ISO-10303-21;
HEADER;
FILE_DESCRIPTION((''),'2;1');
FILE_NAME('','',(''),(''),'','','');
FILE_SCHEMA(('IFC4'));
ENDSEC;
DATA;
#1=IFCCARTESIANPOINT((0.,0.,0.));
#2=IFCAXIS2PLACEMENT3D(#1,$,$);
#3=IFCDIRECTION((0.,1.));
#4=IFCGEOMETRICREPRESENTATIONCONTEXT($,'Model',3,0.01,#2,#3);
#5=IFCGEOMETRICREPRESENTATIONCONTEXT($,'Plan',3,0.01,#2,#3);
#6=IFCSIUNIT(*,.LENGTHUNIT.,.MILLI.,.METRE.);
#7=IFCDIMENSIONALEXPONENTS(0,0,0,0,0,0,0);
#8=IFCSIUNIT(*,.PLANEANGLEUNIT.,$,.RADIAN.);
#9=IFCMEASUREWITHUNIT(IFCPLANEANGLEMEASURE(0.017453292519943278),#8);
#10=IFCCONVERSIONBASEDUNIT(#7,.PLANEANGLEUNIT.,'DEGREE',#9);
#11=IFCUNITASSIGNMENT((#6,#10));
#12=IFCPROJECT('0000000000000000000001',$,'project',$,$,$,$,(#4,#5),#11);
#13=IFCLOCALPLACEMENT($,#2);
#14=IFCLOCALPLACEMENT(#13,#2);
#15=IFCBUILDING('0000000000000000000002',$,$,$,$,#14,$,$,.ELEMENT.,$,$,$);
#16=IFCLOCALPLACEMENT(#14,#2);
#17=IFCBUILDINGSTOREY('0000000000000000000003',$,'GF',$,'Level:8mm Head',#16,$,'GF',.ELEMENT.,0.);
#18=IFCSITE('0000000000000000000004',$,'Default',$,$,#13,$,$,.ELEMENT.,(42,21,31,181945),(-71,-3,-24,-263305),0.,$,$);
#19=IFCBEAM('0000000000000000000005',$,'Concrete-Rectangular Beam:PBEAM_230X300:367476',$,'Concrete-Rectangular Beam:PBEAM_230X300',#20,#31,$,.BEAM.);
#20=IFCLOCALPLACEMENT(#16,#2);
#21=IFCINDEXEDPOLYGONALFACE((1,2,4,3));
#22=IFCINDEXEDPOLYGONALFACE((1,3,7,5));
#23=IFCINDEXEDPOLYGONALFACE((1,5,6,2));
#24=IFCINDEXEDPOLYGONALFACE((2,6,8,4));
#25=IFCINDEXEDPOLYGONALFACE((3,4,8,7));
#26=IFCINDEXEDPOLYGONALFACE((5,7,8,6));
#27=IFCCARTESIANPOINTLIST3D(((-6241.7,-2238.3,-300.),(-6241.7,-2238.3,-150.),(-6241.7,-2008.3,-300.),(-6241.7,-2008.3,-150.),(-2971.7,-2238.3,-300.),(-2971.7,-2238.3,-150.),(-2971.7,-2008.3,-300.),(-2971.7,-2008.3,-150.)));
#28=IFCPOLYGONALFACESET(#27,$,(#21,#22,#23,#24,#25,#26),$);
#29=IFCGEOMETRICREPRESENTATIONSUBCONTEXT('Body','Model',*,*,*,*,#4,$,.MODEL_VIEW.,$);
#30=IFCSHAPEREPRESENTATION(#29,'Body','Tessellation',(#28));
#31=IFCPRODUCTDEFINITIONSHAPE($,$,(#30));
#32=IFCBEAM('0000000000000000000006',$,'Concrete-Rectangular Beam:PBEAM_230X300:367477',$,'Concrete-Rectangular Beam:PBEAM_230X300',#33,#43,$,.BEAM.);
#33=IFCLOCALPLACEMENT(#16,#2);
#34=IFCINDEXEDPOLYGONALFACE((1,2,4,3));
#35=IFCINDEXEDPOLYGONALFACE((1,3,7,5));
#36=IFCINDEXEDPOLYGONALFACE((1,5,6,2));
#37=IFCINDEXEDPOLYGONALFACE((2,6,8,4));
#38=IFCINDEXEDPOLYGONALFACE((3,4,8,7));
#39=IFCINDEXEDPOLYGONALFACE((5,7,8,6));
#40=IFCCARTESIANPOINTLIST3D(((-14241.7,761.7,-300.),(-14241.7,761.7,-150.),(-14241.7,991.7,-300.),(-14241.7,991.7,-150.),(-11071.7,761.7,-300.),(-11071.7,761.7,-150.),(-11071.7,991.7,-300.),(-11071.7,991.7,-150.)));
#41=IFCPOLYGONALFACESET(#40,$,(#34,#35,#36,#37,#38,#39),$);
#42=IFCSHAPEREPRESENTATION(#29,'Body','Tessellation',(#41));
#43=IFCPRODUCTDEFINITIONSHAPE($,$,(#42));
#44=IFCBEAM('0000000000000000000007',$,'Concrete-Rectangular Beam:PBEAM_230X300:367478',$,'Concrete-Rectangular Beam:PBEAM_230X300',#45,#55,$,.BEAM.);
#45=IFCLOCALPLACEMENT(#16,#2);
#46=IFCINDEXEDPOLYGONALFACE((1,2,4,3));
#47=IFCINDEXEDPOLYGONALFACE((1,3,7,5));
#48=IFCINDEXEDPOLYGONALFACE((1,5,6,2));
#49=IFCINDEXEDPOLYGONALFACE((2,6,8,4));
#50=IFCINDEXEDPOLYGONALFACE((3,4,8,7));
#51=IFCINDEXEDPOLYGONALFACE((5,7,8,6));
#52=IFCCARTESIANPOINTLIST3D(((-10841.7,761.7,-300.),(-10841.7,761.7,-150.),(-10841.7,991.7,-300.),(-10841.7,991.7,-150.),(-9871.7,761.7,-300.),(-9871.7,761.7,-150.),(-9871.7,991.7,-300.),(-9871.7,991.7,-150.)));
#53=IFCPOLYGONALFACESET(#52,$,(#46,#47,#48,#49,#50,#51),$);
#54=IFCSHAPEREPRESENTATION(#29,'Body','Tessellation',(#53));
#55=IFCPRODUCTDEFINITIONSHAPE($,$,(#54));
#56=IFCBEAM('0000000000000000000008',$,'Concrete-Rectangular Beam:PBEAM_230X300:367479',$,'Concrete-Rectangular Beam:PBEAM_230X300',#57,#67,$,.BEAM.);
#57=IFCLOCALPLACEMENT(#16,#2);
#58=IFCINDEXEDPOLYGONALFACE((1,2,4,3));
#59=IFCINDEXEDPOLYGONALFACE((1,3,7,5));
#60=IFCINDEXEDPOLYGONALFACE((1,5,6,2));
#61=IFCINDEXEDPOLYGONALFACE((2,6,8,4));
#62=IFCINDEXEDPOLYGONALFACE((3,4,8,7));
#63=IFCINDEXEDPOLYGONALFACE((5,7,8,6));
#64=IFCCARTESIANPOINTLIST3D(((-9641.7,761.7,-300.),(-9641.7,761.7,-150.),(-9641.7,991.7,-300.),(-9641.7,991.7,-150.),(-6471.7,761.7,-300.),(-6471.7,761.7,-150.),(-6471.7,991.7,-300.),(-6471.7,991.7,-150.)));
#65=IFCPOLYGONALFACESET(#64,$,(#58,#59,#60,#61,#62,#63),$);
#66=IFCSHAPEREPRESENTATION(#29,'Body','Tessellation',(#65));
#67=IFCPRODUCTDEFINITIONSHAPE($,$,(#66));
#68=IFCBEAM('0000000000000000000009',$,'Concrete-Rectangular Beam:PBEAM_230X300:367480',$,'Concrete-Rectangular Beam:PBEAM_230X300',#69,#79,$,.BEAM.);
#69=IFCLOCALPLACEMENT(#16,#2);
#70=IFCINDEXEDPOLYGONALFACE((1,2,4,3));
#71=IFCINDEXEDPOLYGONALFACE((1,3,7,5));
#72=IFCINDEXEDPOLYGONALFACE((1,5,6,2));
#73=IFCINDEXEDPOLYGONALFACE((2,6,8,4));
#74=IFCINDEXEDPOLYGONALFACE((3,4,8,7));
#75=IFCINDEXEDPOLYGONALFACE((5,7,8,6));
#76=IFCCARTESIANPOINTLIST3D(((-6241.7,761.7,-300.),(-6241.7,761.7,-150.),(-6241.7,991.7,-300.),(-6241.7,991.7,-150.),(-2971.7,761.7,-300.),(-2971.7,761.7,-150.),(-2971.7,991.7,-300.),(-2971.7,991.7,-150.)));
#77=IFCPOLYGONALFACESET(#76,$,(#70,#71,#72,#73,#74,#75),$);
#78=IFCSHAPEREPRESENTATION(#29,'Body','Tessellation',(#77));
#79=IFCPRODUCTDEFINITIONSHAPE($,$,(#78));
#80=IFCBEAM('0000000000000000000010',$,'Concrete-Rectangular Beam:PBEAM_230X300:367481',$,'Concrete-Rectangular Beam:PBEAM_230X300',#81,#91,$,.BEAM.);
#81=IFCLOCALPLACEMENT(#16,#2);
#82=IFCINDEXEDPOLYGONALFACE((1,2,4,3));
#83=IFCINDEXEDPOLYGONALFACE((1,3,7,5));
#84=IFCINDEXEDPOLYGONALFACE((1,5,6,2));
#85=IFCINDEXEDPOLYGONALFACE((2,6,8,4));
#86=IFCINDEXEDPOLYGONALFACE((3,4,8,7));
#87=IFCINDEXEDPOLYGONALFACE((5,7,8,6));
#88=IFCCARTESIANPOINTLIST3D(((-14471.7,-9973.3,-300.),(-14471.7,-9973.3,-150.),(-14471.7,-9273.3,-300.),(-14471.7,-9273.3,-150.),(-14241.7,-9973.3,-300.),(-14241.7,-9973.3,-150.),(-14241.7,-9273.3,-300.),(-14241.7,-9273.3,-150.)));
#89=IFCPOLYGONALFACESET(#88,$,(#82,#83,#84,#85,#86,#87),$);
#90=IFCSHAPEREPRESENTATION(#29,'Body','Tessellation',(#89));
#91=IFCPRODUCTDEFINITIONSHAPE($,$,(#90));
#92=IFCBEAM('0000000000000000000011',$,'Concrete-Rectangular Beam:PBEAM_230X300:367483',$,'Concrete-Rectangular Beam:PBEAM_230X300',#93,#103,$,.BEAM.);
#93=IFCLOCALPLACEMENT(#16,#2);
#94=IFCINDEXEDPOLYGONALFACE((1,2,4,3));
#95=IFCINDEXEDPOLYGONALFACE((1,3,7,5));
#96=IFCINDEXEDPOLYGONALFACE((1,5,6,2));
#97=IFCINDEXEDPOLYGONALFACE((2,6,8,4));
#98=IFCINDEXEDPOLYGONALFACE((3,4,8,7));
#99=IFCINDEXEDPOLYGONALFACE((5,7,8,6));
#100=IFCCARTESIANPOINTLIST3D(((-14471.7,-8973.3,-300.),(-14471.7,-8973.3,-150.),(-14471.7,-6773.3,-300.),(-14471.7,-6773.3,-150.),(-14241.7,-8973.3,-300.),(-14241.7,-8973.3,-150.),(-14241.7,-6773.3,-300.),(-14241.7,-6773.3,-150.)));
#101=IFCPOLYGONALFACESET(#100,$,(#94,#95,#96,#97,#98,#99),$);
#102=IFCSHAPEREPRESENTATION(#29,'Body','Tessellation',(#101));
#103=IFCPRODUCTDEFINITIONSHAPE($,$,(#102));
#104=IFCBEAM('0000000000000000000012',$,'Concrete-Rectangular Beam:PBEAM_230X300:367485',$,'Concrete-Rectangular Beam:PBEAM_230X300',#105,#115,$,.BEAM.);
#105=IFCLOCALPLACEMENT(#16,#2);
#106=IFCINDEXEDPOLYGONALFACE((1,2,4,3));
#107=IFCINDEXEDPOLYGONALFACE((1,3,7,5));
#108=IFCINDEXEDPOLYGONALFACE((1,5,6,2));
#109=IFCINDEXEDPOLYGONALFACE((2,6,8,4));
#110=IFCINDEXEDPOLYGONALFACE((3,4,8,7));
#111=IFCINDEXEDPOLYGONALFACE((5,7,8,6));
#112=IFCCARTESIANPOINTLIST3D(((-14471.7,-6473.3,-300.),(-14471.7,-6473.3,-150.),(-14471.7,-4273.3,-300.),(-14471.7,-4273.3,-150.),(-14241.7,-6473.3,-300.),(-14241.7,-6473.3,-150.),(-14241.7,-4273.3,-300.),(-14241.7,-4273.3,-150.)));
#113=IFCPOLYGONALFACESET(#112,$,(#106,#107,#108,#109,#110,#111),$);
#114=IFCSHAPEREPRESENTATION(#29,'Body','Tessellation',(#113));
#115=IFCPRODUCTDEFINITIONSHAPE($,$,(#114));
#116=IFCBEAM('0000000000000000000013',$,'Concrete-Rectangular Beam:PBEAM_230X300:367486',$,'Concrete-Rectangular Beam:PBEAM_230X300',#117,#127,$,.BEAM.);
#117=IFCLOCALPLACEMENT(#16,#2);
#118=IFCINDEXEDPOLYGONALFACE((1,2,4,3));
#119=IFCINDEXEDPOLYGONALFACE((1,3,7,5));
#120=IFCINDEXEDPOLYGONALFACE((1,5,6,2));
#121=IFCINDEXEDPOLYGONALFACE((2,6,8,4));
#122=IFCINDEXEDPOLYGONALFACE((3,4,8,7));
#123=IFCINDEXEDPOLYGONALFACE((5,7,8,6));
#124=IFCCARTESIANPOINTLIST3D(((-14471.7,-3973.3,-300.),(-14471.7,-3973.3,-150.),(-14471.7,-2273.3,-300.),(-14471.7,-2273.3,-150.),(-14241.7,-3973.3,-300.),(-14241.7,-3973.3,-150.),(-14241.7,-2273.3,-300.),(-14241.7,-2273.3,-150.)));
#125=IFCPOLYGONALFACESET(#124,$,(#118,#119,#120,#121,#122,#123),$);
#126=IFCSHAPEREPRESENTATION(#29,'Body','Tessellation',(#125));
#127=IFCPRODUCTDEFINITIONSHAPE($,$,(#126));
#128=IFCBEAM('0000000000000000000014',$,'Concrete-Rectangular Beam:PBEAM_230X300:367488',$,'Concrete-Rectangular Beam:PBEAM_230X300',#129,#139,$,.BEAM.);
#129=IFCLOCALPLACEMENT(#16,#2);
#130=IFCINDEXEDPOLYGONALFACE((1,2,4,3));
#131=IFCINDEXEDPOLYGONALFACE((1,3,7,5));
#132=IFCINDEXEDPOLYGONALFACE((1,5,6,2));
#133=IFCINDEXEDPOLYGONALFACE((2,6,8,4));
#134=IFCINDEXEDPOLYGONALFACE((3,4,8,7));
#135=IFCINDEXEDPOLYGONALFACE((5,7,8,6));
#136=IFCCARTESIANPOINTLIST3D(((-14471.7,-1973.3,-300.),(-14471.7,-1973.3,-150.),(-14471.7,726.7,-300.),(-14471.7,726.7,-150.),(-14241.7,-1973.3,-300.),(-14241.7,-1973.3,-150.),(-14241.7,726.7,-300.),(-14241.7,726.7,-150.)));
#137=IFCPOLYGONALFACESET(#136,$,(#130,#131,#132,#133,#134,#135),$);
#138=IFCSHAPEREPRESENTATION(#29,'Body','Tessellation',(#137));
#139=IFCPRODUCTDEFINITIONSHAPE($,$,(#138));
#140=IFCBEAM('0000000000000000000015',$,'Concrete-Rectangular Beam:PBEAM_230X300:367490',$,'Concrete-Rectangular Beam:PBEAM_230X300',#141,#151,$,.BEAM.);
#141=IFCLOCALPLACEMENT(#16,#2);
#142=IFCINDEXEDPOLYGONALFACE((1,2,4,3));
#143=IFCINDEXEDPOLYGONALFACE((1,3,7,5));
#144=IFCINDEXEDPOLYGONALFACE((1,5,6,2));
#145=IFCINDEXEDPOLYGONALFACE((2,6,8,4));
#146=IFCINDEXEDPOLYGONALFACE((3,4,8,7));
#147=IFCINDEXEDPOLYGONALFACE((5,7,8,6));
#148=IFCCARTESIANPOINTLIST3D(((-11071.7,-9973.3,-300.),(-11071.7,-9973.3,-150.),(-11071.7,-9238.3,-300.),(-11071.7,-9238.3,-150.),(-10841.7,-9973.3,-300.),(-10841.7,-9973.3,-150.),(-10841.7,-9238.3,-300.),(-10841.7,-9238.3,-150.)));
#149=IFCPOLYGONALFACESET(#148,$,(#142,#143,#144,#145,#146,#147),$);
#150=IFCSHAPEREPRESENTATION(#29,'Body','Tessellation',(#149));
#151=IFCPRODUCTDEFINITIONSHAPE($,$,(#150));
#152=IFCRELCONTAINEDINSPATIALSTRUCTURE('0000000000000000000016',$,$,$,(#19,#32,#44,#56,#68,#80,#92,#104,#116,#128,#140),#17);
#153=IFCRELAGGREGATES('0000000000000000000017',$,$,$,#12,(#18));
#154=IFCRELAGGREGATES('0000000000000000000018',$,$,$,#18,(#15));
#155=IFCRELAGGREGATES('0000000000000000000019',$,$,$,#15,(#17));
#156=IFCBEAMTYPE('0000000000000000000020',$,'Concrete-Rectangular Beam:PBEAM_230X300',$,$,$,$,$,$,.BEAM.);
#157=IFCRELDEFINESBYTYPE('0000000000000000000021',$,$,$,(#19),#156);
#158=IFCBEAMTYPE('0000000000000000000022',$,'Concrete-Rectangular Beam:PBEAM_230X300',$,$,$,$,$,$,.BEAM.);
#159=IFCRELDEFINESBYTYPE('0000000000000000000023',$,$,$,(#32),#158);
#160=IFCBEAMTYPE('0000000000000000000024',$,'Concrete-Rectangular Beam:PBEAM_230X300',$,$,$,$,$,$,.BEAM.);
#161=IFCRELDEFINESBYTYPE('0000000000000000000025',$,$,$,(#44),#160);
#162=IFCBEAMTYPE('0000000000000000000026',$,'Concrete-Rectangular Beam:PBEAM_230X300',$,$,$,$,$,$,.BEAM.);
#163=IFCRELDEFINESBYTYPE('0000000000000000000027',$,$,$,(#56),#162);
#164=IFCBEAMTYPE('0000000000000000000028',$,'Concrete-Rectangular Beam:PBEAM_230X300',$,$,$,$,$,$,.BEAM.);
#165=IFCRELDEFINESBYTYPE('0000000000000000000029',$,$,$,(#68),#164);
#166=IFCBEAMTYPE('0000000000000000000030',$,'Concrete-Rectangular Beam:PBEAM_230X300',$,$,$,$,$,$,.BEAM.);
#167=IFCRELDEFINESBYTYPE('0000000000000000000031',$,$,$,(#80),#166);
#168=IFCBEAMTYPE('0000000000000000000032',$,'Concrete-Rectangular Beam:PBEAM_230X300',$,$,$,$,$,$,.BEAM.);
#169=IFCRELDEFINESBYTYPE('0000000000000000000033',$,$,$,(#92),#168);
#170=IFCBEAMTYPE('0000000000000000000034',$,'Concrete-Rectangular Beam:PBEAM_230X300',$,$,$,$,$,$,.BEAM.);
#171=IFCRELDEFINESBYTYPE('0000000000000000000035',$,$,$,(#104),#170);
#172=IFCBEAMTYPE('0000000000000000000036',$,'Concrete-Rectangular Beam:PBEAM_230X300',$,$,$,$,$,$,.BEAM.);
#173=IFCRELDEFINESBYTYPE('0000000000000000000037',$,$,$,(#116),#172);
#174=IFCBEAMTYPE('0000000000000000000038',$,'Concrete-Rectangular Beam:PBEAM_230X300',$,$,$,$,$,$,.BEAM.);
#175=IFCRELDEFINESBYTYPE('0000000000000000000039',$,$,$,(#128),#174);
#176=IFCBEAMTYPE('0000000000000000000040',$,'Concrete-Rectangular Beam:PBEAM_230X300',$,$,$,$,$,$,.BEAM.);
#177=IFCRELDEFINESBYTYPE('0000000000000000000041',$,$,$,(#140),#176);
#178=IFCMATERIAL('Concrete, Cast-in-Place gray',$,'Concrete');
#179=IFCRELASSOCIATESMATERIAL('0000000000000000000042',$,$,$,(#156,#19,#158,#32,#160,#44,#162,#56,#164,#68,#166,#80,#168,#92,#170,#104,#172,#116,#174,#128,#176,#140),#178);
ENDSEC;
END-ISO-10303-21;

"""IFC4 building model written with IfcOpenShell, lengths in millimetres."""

from ifc_helpers import new_model, entity, si_unit, converted_unit, direction, frame, origin, place, context, subcontext, project, spatial, indexed_curve, outline, extrude, source, transform, mapped, material, type_object, type_shapes, element, save


model = new_model("IFC4")

# Units and contexts
model_context = context("Model", 3, precision=0.01, world=origin(), true_north=direction((0.0, 1.0)))
plan_context = context("Plan", 3, precision=0.01, world=origin(), true_north=direction((0.0, 1.0)))
body_context = subcontext(model_context, "Body", "Model", "MODEL_VIEW")
ifc_project = project(units=[si_unit("LENGTHUNIT", "METRE", prefix="MILLI"), converted_unit("PLANEANGLEUNIT", "DEGREE", entity("IfcPlaneAngleMeasure", 0.017453292519943278), si_unit("PLANEANGLEUNIT", "RADIAN"), dimensions=[0, 0, 0, 0, 0, 0, 0])], contexts=[model_context, plan_context])

# Site, building, storey
site_placement = place(None, origin())
site = spatial("IfcSite", under=ifc_project, at=site_placement, Name="Default", CompositionType="ELEMENT", RefLatitude=(42, 21, 31, 181945), RefLongitude=(-71, -3, -24, -263305), RefElevation=0.0)
building_placement = place(site_placement, origin())
building = spatial("IfcBuilding", under=site, at=building_placement, CompositionType="ELEMENT")
storey_placement = place(building_placement, origin())
storey = spatial("IfcBuildingStorey", under=building, at=storey_placement, Name="GF", ObjectType="Level:8mm Head", LongName="GF", CompositionType="ELEMENT", Elevation=0.0)

# Beams
ifc_material = material(Name="Concrete, Cast-in-Place gray", Category="Concrete")
beam_type_1 = type_object("IfcBeamType", Name="Concrete-Rectangular Beam:PBEAM_230X300", PredefinedType="BEAM", material=ifc_material)
shared_shape_1 = source(origin(), body_context, "Body", "SweptSolid", [
    extrude(outline(indexed_curve([(-75.0, -115.0), (75.0, -115.0), (75.0, 115.0), (-75.0, 115.0), (-75.0, -115.0)], self_intersect=False)), frame((-6241.7, -2123.3, -225.0), z_axis=(1.0, 0.0, 0.0), x_axis=(0.0, 0.0, -1.0)), (0.0, 0.0, 1.0), 3270.0),
])
type_shapes(beam_type_1, [shared_shape_1])
beam_1_placement = place(storey_placement, origin())
element("IfcBeam", 1, at=beam_1_placement, inside=storey, type_object=beam_type_1, material=ifc_material, Name="Concrete-Rectangular Beam:PBEAM_230X300:367476", ObjectType="Concrete-Rectangular Beam:PBEAM_230X300", PredefinedType="BEAM", context=body_context, shape_type="MappedRepresentation", body=[
    mapped(shared_shape_1, transform((0.0, 0.0, 0.0), scale=1.0)),
])
beam_type_2 = type_object("IfcBeamType", Name="Concrete-Rectangular Beam:PBEAM_230X300", PredefinedType="BEAM", material=ifc_material)
shared_shape_2 = source(origin(), body_context, "Body", "SweptSolid", [
    extrude(outline(indexed_curve([(-75.0, -115.0), (75.0, -115.0), (75.0, 115.0), (-75.0, 115.0), (-75.0, -115.0)], self_intersect=False)), frame((-14241.7, 876.7, -225.0), z_axis=(1.0, 0.0, 0.0), x_axis=(0.0, 0.0, -1.0)), (0.0, 0.0, 1.0), 3170.0),
])
type_shapes(beam_type_2, [shared_shape_2])
beam_2_placement = place(storey_placement, origin())
element("IfcBeam", 2, at=beam_2_placement, inside=storey, type_object=beam_type_2, material=ifc_material, Name="Concrete-Rectangular Beam:PBEAM_230X300:367477", ObjectType="Concrete-Rectangular Beam:PBEAM_230X300", PredefinedType="BEAM", context=body_context, shape_type="MappedRepresentation", body=[
    mapped(shared_shape_2, transform((0.0, 0.0, 0.0), scale=1.0)),
])
beam_type_3 = type_object("IfcBeamType", Name="Concrete-Rectangular Beam:PBEAM_230X300", PredefinedType="BEAM", material=ifc_material)
shared_shape_3 = source(origin(), body_context, "Body", "SweptSolid", [
    extrude(outline(indexed_curve([(-75.0, -115.0), (75.0, -115.0), (75.0, 115.0), (-75.0, 115.0), (-75.0, -115.0)], self_intersect=False)), frame((-10841.7, 876.7, -225.0), z_axis=(1.0, 0.0, 0.0), x_axis=(0.0, 0.0, -1.0)), (0.0, 0.0, 1.0), 970.0),
])
type_shapes(beam_type_3, [shared_shape_3])
beam_3_placement = place(storey_placement, origin())
element("IfcBeam", 3, at=beam_3_placement, inside=storey, type_object=beam_type_3, material=ifc_material, Name="Concrete-Rectangular Beam:PBEAM_230X300:367478", ObjectType="Concrete-Rectangular Beam:PBEAM_230X300", PredefinedType="BEAM", context=body_context, shape_type="MappedRepresentation", body=[
    mapped(shared_shape_3, transform((0.0, 0.0, 0.0), scale=1.0)),
])
beam_type_4 = type_object("IfcBeamType", Name="Concrete-Rectangular Beam:PBEAM_230X300", PredefinedType="BEAM", material=ifc_material)
shared_shape_4 = source(origin(), body_context, "Body", "SweptSolid", [
    extrude(outline(indexed_curve([(-75.0, -115.0), (75.0, -115.0), (75.0, 115.0), (-75.0, 115.0), (-75.0, -115.0)], self_intersect=False)), frame((-9641.7, 876.7, -225.0), z_axis=(1.0, 0.0, 0.0), x_axis=(0.0, 0.0, -1.0)), (0.0, 0.0, 1.0), 3170.0),
])
type_shapes(beam_type_4, [shared_shape_4])
beam_4_placement = place(storey_placement, origin())
element("IfcBeam", 4, at=beam_4_placement, inside=storey, type_object=beam_type_4, material=ifc_material, Name="Concrete-Rectangular Beam:PBEAM_230X300:367479", ObjectType="Concrete-Rectangular Beam:PBEAM_230X300", PredefinedType="BEAM", context=body_context, shape_type="MappedRepresentation", body=[
    mapped(shared_shape_4, transform((0.0, 0.0, 0.0), scale=1.0)),
])
beam_type_5 = type_object("IfcBeamType", Name="Concrete-Rectangular Beam:PBEAM_230X300", PredefinedType="BEAM", material=ifc_material)
shared_shape_5 = source(origin(), body_context, "Body", "SweptSolid", [
    extrude(outline(indexed_curve([(-75.0, -115.0), (75.0, -115.0), (75.0, 115.0), (-75.0, 115.0), (-75.0, -115.0)], self_intersect=False)), frame((-6241.7, 876.7, -225.0), z_axis=(1.0, 0.0, 0.0), x_axis=(0.0, 0.0, -1.0)), (0.0, 0.0, 1.0), 3270.0),
])
type_shapes(beam_type_5, [shared_shape_5])
beam_5_placement = place(storey_placement, origin())
element("IfcBeam", 5, at=beam_5_placement, inside=storey, type_object=beam_type_5, material=ifc_material, Name="Concrete-Rectangular Beam:PBEAM_230X300:367480", ObjectType="Concrete-Rectangular Beam:PBEAM_230X300", PredefinedType="BEAM", context=body_context, shape_type="MappedRepresentation", body=[
    mapped(shared_shape_5, transform((0.0, 0.0, 0.0), scale=1.0)),
])
beam_type_6 = type_object("IfcBeamType", Name="Concrete-Rectangular Beam:PBEAM_230X300", PredefinedType="BEAM", material=ifc_material)
shared_shape_6 = source(origin(), body_context, "Body", "SweptSolid", [
    extrude(outline(indexed_curve([(-115.0, -75.0), (115.0, -75.0), (115.0, 75.0), (-115.0, 75.0), (-115.0, -75.0)], self_intersect=False)), frame((-14356.7, -9973.3, -225.0), z_axis=(0.0, 1.0, 0.0), x_axis=(-1.0, 0.0, 0.0)), (0.0, 0.0, 1.0), 700.0),
])
type_shapes(beam_type_6, [shared_shape_6])
beam_6_placement = place(storey_placement, origin())
element("IfcBeam", 6, at=beam_6_placement, inside=storey, type_object=beam_type_6, material=ifc_material, Name="Concrete-Rectangular Beam:PBEAM_230X300:367481", ObjectType="Concrete-Rectangular Beam:PBEAM_230X300", PredefinedType="BEAM", context=body_context, shape_type="MappedRepresentation", body=[
    mapped(shared_shape_6, transform((0.0, 0.0, 0.0), scale=1.0)),
])
beam_type_7 = type_object("IfcBeamType", Name="Concrete-Rectangular Beam:PBEAM_230X300", PredefinedType="BEAM", material=ifc_material)
shared_shape_7 = source(origin(), body_context, "Body", "SweptSolid", [
    extrude(outline(indexed_curve([(-115.0, -75.0), (115.0, -75.0), (115.0, 75.0), (-115.0, 75.0), (-115.0, -75.0)], self_intersect=False)), frame((-14356.7, -8973.3, -225.0), z_axis=(0.0, 1.0, 0.0), x_axis=(-1.0, 0.0, 0.0)), (0.0, 0.0, 1.0), 2200.0),
])
type_shapes(beam_type_7, [shared_shape_7])
beam_7_placement = place(storey_placement, origin())
element("IfcBeam", 7, at=beam_7_placement, inside=storey, type_object=beam_type_7, material=ifc_material, Name="Concrete-Rectangular Beam:PBEAM_230X300:367483", ObjectType="Concrete-Rectangular Beam:PBEAM_230X300", PredefinedType="BEAM", context=body_context, shape_type="MappedRepresentation", body=[
    mapped(shared_shape_7, transform((0.0, 0.0, 0.0), scale=1.0)),
])
beam_type_8 = type_object("IfcBeamType", Name="Concrete-Rectangular Beam:PBEAM_230X300", PredefinedType="BEAM", material=ifc_material)
shared_shape_8 = source(origin(), body_context, "Body", "SweptSolid", [
    extrude(outline(indexed_curve([(-115.0, -75.0), (115.0, -75.0), (115.0, 75.0), (-115.0, 75.0), (-115.0, -75.0)], self_intersect=False)), frame((-14356.7, -6473.3, -225.0), z_axis=(0.0, 1.0, 0.0), x_axis=(-1.0, 0.0, 0.0)), (0.0, 0.0, 1.0), 2200.0),
])
type_shapes(beam_type_8, [shared_shape_8])
beam_8_placement = place(storey_placement, origin())
element("IfcBeam", 8, at=beam_8_placement, inside=storey, type_object=beam_type_8, material=ifc_material, Name="Concrete-Rectangular Beam:PBEAM_230X300:367485", ObjectType="Concrete-Rectangular Beam:PBEAM_230X300", PredefinedType="BEAM", context=body_context, shape_type="MappedRepresentation", body=[
    mapped(shared_shape_8, transform((0.0, 0.0, 0.0), scale=1.0)),
])
beam_type_9 = type_object("IfcBeamType", Name="Concrete-Rectangular Beam:PBEAM_230X300", PredefinedType="BEAM", material=ifc_material)
shared_shape_9 = source(origin(), body_context, "Body", "SweptSolid", [
    extrude(outline(indexed_curve([(-115.0, -75.0), (115.0, -75.0), (115.0, 75.0), (-115.0, 75.0), (-115.0, -75.0)], self_intersect=False)), frame((-14356.7, -3973.3, -225.0), z_axis=(0.0, 1.0, 0.0), x_axis=(-1.0, 0.0, 0.0)), (0.0, 0.0, 1.0), 1700.0),
])
type_shapes(beam_type_9, [shared_shape_9])
beam_9_placement = place(storey_placement, origin())
element("IfcBeam", 9, at=beam_9_placement, inside=storey, type_object=beam_type_9, material=ifc_material, Name="Concrete-Rectangular Beam:PBEAM_230X300:367486", ObjectType="Concrete-Rectangular Beam:PBEAM_230X300", PredefinedType="BEAM", context=body_context, shape_type="MappedRepresentation", body=[
    mapped(shared_shape_9, transform((0.0, 0.0, 0.0), scale=1.0)),
])
beam_type_10 = type_object("IfcBeamType", Name="Concrete-Rectangular Beam:PBEAM_230X300", PredefinedType="BEAM", material=ifc_material)
shared_shape_10 = source(origin(), body_context, "Body", "SweptSolid", [
    extrude(outline(indexed_curve([(-115.0, -75.0), (115.0, -75.0), (115.0, 75.0), (-115.0, 75.0), (-115.0, -75.0)], self_intersect=False)), frame((-14356.7, -1973.3, -225.0), z_axis=(0.0, 1.0, 0.0), x_axis=(-1.0, 0.0, 0.0)), (0.0, 0.0, 1.0), 2700.0),
])
type_shapes(beam_type_10, [shared_shape_10])
beam_10_placement = place(storey_placement, origin())
element("IfcBeam", 10, at=beam_10_placement, inside=storey, type_object=beam_type_10, material=ifc_material, Name="Concrete-Rectangular Beam:PBEAM_230X300:367488", ObjectType="Concrete-Rectangular Beam:PBEAM_230X300", PredefinedType="BEAM", context=body_context, shape_type="MappedRepresentation", body=[
    mapped(shared_shape_10, transform((0.0, 0.0, 0.0), scale=1.0)),
])
beam_type_11 = type_object("IfcBeamType", Name="Concrete-Rectangular Beam:PBEAM_230X300", PredefinedType="BEAM", material=ifc_material)
shared_shape_11 = source(origin(), body_context, "Body", "SweptSolid", [
    extrude(outline(indexed_curve([(-115.0, -75.0), (115.0, -75.0), (115.0, 75.0), (-115.0, 75.0), (-115.0, -75.0)], self_intersect=False)), frame((-10956.7, -9973.3, -225.0), z_axis=(0.0, 1.0, 0.0), x_axis=(-1.0, 0.0, 0.0)), (0.0, 0.0, 1.0), 735.0),
])
type_shapes(beam_type_11, [shared_shape_11])
beam_11_placement = place(storey_placement, origin())
element("IfcBeam", 11, at=beam_11_placement, inside=storey, type_object=beam_type_11, material=ifc_material, Name="Concrete-Rectangular Beam:PBEAM_230X300:367490", ObjectType="Concrete-Rectangular Beam:PBEAM_230X300", PredefinedType="BEAM", context=body_context, shape_type="MappedRepresentation", body=[
    mapped(shared_shape_11, transform((0.0, 0.0, 0.0), scale=1.0)),
])

save(model, "model.ifc")
